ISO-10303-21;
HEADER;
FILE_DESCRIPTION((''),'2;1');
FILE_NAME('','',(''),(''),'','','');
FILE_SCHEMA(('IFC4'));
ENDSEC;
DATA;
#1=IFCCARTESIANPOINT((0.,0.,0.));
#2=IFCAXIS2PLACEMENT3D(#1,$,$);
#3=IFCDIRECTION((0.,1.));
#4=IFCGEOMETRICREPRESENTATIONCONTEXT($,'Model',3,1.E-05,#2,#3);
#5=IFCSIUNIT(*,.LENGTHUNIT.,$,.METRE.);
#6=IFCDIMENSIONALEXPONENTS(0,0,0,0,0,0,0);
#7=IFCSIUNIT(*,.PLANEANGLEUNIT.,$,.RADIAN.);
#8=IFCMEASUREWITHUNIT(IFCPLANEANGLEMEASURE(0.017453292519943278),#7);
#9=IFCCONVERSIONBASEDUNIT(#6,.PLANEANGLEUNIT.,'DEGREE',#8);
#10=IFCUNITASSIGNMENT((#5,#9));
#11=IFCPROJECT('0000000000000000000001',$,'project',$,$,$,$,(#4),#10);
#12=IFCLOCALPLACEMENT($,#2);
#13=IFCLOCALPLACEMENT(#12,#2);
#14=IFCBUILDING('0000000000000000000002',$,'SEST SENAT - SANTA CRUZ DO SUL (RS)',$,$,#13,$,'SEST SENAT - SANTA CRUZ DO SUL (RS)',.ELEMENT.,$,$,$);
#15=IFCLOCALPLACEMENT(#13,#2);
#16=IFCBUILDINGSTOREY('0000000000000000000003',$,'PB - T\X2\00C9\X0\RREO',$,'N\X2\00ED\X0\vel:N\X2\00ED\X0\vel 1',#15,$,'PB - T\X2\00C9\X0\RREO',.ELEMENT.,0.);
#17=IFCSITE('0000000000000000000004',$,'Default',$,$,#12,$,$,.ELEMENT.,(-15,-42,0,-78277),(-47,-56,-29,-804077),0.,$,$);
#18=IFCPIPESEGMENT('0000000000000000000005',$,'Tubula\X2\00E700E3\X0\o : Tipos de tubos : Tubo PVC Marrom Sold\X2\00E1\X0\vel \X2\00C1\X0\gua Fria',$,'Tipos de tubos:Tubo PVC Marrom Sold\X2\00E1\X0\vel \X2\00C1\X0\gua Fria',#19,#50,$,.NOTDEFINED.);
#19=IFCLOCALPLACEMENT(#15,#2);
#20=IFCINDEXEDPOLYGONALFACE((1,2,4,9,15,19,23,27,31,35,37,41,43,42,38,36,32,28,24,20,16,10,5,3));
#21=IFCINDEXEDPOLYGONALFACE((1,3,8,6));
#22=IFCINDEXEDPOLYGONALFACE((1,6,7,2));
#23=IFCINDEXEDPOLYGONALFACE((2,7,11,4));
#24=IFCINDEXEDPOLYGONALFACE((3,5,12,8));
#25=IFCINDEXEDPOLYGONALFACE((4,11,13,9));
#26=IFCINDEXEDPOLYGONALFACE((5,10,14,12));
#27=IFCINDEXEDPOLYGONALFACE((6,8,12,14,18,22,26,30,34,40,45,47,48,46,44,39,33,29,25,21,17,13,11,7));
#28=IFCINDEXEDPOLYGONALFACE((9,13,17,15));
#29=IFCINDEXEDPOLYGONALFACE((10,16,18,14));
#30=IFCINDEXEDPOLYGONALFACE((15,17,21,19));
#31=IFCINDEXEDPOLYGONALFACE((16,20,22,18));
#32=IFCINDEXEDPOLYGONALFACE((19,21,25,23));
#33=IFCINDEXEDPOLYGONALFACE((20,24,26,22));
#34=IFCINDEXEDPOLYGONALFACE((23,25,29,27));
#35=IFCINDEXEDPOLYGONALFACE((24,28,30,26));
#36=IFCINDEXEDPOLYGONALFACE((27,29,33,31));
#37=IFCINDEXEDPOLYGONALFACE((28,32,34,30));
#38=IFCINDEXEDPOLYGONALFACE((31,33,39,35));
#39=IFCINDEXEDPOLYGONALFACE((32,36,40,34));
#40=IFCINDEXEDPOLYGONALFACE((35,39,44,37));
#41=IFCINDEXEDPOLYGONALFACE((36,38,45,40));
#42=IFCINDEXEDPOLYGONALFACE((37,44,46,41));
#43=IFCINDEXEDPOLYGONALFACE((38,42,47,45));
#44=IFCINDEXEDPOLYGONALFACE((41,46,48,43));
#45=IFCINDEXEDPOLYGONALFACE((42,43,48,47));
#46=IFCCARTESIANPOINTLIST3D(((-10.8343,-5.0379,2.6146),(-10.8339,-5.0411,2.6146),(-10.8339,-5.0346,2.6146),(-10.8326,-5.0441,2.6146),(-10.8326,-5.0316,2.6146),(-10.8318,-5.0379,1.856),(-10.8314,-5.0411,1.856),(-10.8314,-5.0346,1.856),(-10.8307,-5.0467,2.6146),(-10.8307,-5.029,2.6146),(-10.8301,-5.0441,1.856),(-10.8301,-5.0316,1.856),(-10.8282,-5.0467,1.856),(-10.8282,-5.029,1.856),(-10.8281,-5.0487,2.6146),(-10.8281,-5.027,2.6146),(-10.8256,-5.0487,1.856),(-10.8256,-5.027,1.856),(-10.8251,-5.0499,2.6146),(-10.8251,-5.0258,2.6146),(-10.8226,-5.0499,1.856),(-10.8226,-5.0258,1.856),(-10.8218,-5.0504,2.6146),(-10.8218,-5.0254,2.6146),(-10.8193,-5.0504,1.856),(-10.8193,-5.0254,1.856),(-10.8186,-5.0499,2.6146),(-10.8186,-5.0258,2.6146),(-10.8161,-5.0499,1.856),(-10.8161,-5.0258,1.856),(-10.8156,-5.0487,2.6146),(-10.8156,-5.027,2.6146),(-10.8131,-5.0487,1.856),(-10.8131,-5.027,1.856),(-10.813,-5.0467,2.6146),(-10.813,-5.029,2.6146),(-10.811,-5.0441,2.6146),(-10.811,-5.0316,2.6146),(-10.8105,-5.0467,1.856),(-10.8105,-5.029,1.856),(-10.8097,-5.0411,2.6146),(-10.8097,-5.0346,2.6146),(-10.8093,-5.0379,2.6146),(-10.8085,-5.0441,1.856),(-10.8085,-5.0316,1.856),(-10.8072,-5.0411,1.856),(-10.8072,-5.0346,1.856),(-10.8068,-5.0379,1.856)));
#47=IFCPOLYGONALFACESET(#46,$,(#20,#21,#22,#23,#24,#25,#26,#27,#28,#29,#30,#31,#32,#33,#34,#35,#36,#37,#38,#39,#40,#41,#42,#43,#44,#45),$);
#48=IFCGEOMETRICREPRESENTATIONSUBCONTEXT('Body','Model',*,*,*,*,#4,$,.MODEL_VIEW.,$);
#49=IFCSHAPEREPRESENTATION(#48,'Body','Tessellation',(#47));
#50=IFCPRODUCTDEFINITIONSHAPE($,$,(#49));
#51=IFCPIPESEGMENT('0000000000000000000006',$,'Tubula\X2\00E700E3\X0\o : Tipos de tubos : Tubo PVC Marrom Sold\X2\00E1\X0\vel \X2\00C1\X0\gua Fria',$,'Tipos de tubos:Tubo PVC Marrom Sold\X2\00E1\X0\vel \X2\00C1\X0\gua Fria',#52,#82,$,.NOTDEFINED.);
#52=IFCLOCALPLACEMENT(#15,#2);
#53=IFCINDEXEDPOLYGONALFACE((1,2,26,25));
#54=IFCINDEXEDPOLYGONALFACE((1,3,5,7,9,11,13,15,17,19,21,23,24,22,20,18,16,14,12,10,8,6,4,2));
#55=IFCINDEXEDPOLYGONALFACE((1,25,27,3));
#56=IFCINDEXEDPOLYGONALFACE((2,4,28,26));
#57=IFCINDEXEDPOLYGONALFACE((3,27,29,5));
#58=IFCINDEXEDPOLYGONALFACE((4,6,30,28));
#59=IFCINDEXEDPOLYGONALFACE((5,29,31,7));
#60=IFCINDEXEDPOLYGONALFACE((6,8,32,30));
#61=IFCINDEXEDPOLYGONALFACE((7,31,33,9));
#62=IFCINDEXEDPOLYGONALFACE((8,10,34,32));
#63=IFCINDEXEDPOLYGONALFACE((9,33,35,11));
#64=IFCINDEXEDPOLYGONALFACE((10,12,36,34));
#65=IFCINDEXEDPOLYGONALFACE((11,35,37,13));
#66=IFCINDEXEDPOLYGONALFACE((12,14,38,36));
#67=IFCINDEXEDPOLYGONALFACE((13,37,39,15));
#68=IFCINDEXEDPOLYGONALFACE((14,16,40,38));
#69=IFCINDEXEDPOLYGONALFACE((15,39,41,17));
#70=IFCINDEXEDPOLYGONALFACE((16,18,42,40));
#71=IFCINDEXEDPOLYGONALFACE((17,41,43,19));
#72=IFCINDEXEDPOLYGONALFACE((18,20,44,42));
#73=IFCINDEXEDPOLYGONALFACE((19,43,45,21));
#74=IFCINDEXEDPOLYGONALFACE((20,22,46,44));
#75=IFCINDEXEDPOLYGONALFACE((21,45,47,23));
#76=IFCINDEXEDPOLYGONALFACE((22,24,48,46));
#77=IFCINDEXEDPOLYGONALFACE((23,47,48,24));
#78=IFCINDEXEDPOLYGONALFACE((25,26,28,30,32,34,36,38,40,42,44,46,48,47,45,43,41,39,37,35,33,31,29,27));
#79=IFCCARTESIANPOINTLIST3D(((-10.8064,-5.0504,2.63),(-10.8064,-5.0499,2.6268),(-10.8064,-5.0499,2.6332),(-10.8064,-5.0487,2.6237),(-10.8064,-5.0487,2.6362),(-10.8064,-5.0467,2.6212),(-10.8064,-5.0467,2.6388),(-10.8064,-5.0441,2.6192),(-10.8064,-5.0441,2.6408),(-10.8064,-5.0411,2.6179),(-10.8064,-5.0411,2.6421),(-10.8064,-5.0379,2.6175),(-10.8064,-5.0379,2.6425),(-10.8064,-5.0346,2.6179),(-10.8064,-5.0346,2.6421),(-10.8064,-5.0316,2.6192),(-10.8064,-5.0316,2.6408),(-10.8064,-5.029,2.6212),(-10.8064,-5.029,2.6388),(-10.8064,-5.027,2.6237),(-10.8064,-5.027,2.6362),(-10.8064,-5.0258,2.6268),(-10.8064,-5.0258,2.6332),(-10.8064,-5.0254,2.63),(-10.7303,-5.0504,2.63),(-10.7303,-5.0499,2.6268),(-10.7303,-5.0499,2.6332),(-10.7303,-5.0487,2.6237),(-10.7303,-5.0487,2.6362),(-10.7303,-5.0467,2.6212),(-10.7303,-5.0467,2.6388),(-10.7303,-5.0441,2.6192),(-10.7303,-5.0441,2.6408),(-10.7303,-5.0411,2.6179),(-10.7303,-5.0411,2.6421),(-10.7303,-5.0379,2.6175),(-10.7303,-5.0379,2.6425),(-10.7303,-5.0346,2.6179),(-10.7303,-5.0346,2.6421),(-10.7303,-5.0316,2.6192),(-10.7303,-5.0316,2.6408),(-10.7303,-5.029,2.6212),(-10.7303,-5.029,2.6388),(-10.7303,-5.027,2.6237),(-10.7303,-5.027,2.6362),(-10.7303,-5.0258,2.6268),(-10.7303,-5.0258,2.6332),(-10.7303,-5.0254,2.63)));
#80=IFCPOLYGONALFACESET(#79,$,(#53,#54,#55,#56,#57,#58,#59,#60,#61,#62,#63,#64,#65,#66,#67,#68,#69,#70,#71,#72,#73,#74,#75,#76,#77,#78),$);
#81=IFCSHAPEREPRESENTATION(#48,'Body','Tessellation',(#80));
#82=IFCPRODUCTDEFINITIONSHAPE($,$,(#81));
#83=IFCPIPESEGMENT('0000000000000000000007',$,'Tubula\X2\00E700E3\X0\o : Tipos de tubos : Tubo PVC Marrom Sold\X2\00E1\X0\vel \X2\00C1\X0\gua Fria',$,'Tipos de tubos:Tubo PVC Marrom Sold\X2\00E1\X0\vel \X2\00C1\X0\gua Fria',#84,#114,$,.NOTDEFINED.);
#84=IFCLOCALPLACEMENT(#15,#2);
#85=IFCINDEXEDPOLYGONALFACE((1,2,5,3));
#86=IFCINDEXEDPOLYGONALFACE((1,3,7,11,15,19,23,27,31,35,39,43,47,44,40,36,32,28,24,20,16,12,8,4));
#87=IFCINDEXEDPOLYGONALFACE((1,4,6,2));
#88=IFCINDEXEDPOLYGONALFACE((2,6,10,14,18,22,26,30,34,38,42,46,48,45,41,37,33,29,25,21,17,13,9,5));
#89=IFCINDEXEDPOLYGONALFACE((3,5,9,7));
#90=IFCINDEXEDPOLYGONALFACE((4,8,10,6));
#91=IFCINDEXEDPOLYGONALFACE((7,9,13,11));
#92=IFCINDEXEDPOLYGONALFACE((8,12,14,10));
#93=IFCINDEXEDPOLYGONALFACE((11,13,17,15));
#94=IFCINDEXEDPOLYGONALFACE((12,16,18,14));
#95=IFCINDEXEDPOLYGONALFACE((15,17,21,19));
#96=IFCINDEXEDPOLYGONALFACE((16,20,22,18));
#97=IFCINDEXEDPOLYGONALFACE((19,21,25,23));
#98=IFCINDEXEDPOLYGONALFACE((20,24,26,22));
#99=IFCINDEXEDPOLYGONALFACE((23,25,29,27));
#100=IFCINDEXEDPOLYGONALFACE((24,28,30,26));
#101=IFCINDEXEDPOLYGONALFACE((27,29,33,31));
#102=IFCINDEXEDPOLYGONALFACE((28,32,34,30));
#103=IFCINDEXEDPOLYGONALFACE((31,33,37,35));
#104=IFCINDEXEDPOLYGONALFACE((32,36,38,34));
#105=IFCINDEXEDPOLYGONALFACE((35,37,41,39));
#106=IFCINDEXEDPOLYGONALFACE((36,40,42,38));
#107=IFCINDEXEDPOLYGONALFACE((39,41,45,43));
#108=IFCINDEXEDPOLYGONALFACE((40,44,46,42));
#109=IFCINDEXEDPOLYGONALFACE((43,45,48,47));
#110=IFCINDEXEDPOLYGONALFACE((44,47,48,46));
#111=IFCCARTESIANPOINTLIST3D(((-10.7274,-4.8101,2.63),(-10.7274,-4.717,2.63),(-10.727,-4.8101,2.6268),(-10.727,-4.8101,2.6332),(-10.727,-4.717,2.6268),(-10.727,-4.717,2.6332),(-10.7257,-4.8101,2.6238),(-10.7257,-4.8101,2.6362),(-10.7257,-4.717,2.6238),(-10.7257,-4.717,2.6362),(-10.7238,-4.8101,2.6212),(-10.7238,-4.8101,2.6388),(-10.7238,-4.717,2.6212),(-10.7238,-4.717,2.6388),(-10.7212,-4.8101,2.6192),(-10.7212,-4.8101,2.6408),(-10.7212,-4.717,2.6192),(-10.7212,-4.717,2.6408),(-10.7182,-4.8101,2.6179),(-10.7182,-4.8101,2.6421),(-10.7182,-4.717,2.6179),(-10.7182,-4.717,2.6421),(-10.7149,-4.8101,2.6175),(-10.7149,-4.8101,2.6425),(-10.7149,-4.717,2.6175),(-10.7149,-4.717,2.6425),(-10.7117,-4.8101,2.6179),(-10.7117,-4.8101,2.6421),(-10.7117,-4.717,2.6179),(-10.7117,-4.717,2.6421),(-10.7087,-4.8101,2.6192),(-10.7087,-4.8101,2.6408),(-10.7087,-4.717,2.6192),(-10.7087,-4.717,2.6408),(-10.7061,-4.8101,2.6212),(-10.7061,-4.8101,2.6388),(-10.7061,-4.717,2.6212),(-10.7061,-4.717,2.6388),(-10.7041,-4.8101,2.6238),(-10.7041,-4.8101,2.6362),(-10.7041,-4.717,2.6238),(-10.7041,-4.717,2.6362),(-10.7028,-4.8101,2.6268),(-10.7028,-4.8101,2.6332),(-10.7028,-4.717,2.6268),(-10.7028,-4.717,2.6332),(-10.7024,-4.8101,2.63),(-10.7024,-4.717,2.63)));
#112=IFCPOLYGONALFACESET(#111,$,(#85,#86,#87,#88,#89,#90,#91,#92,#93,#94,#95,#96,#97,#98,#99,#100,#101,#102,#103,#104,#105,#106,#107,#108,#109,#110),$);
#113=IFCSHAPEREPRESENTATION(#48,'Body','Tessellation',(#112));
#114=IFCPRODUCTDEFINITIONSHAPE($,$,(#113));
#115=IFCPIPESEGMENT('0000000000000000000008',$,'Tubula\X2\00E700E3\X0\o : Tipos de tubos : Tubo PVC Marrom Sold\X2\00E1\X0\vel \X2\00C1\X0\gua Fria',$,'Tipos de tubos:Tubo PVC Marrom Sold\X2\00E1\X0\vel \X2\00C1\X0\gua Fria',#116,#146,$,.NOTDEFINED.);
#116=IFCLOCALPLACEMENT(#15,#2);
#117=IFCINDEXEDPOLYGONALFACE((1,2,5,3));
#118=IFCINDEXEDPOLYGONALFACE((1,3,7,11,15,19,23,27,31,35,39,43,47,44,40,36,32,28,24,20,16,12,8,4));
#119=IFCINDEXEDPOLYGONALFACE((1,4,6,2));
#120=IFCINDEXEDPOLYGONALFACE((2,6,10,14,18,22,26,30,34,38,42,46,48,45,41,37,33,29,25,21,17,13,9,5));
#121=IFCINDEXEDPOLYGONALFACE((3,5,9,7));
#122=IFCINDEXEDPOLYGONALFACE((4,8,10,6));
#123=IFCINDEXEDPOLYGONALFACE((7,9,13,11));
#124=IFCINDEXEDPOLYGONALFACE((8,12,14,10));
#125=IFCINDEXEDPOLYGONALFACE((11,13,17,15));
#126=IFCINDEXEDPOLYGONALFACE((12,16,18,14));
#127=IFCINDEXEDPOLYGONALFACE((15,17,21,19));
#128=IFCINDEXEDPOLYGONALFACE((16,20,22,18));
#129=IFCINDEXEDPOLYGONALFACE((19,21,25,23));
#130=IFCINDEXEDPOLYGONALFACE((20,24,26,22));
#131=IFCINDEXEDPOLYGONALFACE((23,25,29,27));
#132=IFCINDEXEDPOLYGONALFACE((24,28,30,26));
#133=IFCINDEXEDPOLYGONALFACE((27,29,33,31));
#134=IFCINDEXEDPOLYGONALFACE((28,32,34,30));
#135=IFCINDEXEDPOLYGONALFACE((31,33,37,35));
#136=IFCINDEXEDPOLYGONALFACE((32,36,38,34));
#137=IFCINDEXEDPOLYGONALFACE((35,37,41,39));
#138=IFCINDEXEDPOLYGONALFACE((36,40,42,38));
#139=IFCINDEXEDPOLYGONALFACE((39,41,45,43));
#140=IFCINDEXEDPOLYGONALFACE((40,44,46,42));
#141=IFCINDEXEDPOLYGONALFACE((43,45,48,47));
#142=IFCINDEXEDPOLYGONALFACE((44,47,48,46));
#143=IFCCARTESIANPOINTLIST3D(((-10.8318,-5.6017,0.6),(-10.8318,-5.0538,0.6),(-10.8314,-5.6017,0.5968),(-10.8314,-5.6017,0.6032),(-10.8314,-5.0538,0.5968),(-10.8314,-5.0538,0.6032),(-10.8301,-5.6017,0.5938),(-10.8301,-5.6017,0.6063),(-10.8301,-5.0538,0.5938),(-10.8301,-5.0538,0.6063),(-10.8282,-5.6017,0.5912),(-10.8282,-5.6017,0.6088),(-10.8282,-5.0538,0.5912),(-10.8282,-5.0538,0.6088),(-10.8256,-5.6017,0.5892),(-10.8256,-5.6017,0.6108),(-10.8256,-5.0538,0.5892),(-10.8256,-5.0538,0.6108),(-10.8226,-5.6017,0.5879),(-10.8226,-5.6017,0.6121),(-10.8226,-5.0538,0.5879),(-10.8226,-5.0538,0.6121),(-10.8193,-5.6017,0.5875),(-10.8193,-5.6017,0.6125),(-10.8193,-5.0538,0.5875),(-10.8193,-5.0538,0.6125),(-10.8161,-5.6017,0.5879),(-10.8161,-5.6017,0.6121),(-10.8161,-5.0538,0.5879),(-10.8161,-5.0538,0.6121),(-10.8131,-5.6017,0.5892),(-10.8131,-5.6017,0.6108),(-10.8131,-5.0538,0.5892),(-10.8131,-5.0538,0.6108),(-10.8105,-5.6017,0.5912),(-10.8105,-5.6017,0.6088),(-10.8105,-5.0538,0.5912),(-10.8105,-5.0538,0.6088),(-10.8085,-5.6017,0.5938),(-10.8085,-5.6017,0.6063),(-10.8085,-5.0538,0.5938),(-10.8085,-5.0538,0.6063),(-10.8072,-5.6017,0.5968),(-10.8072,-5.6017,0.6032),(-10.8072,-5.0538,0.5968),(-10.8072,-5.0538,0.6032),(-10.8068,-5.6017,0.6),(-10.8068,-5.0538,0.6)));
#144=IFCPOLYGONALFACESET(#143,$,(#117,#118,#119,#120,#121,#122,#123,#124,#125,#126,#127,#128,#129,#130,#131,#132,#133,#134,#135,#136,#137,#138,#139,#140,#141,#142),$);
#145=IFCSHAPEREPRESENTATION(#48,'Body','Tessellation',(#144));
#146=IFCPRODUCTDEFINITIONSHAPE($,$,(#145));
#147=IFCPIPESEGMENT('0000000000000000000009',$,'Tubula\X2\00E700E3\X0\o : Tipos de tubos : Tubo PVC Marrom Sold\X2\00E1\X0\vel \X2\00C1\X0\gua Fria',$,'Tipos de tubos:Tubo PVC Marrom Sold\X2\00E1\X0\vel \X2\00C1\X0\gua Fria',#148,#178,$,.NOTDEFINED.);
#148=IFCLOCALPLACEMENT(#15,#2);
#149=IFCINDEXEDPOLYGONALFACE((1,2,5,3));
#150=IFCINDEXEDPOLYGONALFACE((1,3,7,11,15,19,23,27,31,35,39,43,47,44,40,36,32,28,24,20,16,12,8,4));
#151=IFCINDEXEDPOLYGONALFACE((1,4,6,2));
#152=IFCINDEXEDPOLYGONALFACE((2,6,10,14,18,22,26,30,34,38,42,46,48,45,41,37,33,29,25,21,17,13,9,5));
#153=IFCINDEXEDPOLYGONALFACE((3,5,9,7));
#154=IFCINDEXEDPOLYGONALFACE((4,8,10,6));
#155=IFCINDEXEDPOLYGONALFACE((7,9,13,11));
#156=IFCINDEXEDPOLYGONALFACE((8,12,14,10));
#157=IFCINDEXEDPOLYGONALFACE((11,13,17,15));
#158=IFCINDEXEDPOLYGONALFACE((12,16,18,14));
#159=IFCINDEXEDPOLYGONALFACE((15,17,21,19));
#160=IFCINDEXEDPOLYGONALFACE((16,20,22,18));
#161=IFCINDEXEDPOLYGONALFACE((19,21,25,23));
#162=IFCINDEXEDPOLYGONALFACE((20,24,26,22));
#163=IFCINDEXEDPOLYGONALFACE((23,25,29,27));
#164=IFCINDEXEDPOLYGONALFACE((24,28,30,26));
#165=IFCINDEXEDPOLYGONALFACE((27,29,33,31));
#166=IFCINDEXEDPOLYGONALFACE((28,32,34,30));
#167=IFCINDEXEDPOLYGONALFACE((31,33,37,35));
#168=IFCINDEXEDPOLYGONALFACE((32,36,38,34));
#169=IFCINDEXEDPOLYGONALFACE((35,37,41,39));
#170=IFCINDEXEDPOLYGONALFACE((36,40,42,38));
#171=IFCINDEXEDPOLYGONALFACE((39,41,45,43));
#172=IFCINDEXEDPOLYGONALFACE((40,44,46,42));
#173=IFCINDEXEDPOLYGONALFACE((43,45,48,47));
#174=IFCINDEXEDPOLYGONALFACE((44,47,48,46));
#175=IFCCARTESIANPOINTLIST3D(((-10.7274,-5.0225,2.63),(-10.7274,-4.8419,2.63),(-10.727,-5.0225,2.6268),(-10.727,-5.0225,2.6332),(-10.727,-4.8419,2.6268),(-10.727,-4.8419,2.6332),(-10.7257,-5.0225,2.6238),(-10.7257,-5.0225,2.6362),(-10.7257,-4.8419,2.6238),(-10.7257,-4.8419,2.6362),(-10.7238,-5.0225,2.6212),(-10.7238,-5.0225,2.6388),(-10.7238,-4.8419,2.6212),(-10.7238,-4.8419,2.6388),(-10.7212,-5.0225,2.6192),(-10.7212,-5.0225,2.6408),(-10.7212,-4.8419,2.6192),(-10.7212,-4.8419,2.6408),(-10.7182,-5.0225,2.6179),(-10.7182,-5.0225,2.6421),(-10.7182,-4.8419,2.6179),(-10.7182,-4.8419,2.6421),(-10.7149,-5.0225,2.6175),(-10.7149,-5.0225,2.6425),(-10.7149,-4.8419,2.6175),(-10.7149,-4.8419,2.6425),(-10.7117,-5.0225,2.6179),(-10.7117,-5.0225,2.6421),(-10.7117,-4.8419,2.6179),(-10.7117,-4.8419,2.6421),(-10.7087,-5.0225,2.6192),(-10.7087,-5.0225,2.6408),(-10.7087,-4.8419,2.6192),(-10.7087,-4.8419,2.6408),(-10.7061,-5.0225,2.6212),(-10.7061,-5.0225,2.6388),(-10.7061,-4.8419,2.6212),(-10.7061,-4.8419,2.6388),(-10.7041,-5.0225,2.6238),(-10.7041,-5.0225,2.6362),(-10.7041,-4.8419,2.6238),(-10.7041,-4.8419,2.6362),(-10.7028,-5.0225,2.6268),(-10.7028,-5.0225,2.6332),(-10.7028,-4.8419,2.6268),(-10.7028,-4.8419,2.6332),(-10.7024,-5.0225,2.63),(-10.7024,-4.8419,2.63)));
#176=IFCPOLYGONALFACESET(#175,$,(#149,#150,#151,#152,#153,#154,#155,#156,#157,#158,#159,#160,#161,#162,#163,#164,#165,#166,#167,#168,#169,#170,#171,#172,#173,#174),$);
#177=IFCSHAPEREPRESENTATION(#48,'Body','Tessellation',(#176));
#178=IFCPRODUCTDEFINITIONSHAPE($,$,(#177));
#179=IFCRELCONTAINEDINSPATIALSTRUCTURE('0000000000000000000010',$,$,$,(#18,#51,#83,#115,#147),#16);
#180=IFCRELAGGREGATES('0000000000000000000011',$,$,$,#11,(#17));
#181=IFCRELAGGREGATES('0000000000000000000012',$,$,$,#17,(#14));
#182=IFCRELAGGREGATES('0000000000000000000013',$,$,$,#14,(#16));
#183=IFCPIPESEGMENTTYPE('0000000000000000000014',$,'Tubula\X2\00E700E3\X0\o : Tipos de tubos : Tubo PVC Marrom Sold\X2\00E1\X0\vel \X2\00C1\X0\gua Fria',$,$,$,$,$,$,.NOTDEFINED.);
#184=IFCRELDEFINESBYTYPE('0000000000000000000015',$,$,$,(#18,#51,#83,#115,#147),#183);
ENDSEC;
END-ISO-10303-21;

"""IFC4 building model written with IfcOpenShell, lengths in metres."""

from ifc_helpers import new_model, entity, si_unit, converted_unit, direction, frame, origin, place, context, subcontext, project, spatial, arc, indexed_curve, outline, extrude, type_object, element, save


model = new_model("IFC4")

# Units and contexts
model_context = context("Model", 3, precision=1e-05, world=origin(), true_north=direction((0.0, 1.0)))
body_context = subcontext(model_context, "Body", "Model", "MODEL_VIEW")
ifc_project = project(units=[si_unit("LENGTHUNIT", "METRE"), converted_unit("PLANEANGLEUNIT", "DEGREE", entity("IfcPlaneAngleMeasure", 0.017453292519943278), si_unit("PLANEANGLEUNIT", "RADIAN"), dimensions=[0, 0, 0, 0, 0, 0, 0])], contexts=[model_context])

# Site, building, storey
site_placement = place(None, origin())
site = spatial("IfcSite", under=ifc_project, at=site_placement, Name="Default", CompositionType="ELEMENT", RefLatitude=(-15, -42, 0, -78277), RefLongitude=(-47, -56, -29, -804077), RefElevation=0.0)
building_placement = place(site_placement, origin())
building = spatial("IfcBuilding", under=site, at=building_placement, Name="SEST SENAT - SANTA CRUZ DO SUL (RS)", LongName="SEST SENAT - SANTA CRUZ DO SUL (RS)", CompositionType="ELEMENT")
storey_placement = place(building_placement, origin())
storey = spatial("IfcBuildingStorey", under=building, at=storey_placement, Name="PB - TÉRREO", ObjectType="Nível:Nível 1", LongName="PB - TÉRREO", CompositionType="ELEMENT", Elevation=0.0)

# Pipe segments
pipe_segment_type_1 = type_object("IfcPipeSegmentType", Name="Tubulação : Tipos de tubos : Tubo PVC Marrom Soldável Água Fria", PredefinedType="NOTDEFINED")
pipe_segment_1_placement = place(storey_placement, frame((-10.8359, -5.052, 2.6146)))
element("IfcPipeSegment", 1, at=pipe_segment_1_placement, inside=storey, type_object=pipe_segment_type_1, Name="Tubulação : Tipos de tubos : Tubo PVC Marrom Soldável Água Fria", ObjectType="Tipos de tubos:Tubo PVC Marrom Soldável Água Fria", PredefinedType="NOTDEFINED", context=body_context, shape_type="SweptSolid", body=[
    extrude(outline(indexed_curve([(0.0125, 0.0), (0.0088, 0.0088), (0.0, 0.0125), (-0.0088, 0.0088), (-0.0125, 0.0), (-0.0088, -0.0088), (0.0, -0.0125), (0.0088, -0.0088)], segments=[arc(1, 2, 3), arc(3, 4, 5), arc(5, 6, 7), arc(7, 8, 1)], self_intersect=False)), frame((0.0166, 0.0141, -0.7586), z_axis=(-0.003296, 0.0, 0.999995), x_axis=(0.0, -1.0, 0.0)), (0.0, 0.0, 1.0), 0.7586),
])
pipe_segment_2_placement = place(storey_placement, frame((-10.8064, -5.052, 2.6159)))
element("IfcPipeSegment", 2, at=pipe_segment_2_placement, inside=storey, type_object=pipe_segment_type_1, Name="Tubulação : Tipos de tubos : Tubo PVC Marrom Soldável Água Fria", ObjectType="Tipos de tubos:Tubo PVC Marrom Soldável Água Fria", PredefinedType="NOTDEFINED", context=body_context, shape_type="SweptSolid", body=[
    extrude(outline(indexed_curve([(0.0125, 0.0), (0.0088, 0.0088), (0.0, 0.0125), (-0.0088, 0.0088), (-0.0125, 0.0), (-0.0088, -0.0088), (0.0, -0.0125), (0.0088, -0.0088)], segments=[arc(1, 2, 3), arc(3, 4, 5), arc(5, 6, 7), arc(7, 8, 1)], self_intersect=False)), frame((0.0, 0.0141, 0.0141), z_axis=(1.0, 0.0, 0.0), x_axis=(0.0, -1.0, 0.0)), (0.0, 0.0, 1.0), 0.0761),
])
pipe_segment_3_placement = place(storey_placement, frame((-10.729, -4.8101, 2.6159)))
element("IfcPipeSegment", 3, at=pipe_segment_3_placement, inside=storey, type_object=pipe_segment_type_1, Name="Tubulação : Tipos de tubos : Tubo PVC Marrom Soldável Água Fria", ObjectType="Tipos de tubos:Tubo PVC Marrom Soldável Água Fria", PredefinedType="NOTDEFINED", context=body_context, shape_type="SweptSolid", body=[
    extrude(outline(indexed_curve([(0.0125, 0.0), (0.0088, 0.0088), (0.0, 0.0125), (-0.0088, 0.0088), (-0.0125, 0.0), (-0.0088, -0.0088), (0.0, -0.0125), (0.0088, -0.0088)], segments=[arc(1, 2, 3), arc(3, 4, 5), arc(5, 6, 7), arc(7, 8, 1)], self_intersect=False)), frame((0.0141, 0.0, 0.0141), z_axis=(0.0, 1.0, 0.0), x_axis=(1.0, 0.0, 0.0)), (0.0, 0.0, 1.0), 0.0931),
])
pipe_segment_4_placement = place(storey_placement, frame((-10.8334, -5.6017, 0.5859)))
element("IfcPipeSegment", 4, at=pipe_segment_4_placement, inside=storey, type_object=pipe_segment_type_1, Name="Tubulação : Tipos de tubos : Tubo PVC Marrom Soldável Água Fria", ObjectType="Tipos de tubos:Tubo PVC Marrom Soldável Água Fria", PredefinedType="NOTDEFINED", context=body_context, shape_type="SweptSolid", body=[
    extrude(outline(indexed_curve([(0.0125, 0.0), (0.0088, 0.0088), (0.0, 0.0125), (-0.0088, 0.0088), (-0.0125, 0.0), (-0.0088, -0.0088), (0.0, -0.0125), (0.0088, -0.0088)], segments=[arc(1, 2, 3), arc(3, 4, 5), arc(5, 6, 7), arc(7, 8, 1)], self_intersect=False)), frame((0.0141, 0.0, 0.0141), z_axis=(0.0, 1.0, 0.0), x_axis=(1.0, 0.0, 0.0)), (0.0, 0.0, 1.0), 0.548),
])
pipe_segment_5_placement = place(storey_placement, frame((-10.729, -5.0225, 2.6159)))
element("IfcPipeSegment", 5, at=pipe_segment_5_placement, inside=storey, type_object=pipe_segment_type_1, Name="Tubulação : Tipos de tubos : Tubo PVC Marrom Soldável Água Fria", ObjectType="Tipos de tubos:Tubo PVC Marrom Soldável Água Fria", PredefinedType="NOTDEFINED", context=body_context, shape_type="SweptSolid", body=[
    extrude(outline(indexed_curve([(0.0125, 0.0), (0.0088, 0.0088), (0.0, 0.0125), (-0.0088, 0.0088), (-0.0125, 0.0), (-0.0088, -0.0088), (0.0, -0.0125), (0.0088, -0.0088)], segments=[arc(1, 2, 3), arc(3, 4, 5), arc(5, 6, 7), arc(7, 8, 1)], self_intersect=False)), frame((0.0141, 0.0, 0.0141), z_axis=(0.0, 1.0, 0.0), x_axis=(1.0, 0.0, 0.0)), (0.0, 0.0, 1.0), 0.1806),
])

save(model, "model.ifc")
